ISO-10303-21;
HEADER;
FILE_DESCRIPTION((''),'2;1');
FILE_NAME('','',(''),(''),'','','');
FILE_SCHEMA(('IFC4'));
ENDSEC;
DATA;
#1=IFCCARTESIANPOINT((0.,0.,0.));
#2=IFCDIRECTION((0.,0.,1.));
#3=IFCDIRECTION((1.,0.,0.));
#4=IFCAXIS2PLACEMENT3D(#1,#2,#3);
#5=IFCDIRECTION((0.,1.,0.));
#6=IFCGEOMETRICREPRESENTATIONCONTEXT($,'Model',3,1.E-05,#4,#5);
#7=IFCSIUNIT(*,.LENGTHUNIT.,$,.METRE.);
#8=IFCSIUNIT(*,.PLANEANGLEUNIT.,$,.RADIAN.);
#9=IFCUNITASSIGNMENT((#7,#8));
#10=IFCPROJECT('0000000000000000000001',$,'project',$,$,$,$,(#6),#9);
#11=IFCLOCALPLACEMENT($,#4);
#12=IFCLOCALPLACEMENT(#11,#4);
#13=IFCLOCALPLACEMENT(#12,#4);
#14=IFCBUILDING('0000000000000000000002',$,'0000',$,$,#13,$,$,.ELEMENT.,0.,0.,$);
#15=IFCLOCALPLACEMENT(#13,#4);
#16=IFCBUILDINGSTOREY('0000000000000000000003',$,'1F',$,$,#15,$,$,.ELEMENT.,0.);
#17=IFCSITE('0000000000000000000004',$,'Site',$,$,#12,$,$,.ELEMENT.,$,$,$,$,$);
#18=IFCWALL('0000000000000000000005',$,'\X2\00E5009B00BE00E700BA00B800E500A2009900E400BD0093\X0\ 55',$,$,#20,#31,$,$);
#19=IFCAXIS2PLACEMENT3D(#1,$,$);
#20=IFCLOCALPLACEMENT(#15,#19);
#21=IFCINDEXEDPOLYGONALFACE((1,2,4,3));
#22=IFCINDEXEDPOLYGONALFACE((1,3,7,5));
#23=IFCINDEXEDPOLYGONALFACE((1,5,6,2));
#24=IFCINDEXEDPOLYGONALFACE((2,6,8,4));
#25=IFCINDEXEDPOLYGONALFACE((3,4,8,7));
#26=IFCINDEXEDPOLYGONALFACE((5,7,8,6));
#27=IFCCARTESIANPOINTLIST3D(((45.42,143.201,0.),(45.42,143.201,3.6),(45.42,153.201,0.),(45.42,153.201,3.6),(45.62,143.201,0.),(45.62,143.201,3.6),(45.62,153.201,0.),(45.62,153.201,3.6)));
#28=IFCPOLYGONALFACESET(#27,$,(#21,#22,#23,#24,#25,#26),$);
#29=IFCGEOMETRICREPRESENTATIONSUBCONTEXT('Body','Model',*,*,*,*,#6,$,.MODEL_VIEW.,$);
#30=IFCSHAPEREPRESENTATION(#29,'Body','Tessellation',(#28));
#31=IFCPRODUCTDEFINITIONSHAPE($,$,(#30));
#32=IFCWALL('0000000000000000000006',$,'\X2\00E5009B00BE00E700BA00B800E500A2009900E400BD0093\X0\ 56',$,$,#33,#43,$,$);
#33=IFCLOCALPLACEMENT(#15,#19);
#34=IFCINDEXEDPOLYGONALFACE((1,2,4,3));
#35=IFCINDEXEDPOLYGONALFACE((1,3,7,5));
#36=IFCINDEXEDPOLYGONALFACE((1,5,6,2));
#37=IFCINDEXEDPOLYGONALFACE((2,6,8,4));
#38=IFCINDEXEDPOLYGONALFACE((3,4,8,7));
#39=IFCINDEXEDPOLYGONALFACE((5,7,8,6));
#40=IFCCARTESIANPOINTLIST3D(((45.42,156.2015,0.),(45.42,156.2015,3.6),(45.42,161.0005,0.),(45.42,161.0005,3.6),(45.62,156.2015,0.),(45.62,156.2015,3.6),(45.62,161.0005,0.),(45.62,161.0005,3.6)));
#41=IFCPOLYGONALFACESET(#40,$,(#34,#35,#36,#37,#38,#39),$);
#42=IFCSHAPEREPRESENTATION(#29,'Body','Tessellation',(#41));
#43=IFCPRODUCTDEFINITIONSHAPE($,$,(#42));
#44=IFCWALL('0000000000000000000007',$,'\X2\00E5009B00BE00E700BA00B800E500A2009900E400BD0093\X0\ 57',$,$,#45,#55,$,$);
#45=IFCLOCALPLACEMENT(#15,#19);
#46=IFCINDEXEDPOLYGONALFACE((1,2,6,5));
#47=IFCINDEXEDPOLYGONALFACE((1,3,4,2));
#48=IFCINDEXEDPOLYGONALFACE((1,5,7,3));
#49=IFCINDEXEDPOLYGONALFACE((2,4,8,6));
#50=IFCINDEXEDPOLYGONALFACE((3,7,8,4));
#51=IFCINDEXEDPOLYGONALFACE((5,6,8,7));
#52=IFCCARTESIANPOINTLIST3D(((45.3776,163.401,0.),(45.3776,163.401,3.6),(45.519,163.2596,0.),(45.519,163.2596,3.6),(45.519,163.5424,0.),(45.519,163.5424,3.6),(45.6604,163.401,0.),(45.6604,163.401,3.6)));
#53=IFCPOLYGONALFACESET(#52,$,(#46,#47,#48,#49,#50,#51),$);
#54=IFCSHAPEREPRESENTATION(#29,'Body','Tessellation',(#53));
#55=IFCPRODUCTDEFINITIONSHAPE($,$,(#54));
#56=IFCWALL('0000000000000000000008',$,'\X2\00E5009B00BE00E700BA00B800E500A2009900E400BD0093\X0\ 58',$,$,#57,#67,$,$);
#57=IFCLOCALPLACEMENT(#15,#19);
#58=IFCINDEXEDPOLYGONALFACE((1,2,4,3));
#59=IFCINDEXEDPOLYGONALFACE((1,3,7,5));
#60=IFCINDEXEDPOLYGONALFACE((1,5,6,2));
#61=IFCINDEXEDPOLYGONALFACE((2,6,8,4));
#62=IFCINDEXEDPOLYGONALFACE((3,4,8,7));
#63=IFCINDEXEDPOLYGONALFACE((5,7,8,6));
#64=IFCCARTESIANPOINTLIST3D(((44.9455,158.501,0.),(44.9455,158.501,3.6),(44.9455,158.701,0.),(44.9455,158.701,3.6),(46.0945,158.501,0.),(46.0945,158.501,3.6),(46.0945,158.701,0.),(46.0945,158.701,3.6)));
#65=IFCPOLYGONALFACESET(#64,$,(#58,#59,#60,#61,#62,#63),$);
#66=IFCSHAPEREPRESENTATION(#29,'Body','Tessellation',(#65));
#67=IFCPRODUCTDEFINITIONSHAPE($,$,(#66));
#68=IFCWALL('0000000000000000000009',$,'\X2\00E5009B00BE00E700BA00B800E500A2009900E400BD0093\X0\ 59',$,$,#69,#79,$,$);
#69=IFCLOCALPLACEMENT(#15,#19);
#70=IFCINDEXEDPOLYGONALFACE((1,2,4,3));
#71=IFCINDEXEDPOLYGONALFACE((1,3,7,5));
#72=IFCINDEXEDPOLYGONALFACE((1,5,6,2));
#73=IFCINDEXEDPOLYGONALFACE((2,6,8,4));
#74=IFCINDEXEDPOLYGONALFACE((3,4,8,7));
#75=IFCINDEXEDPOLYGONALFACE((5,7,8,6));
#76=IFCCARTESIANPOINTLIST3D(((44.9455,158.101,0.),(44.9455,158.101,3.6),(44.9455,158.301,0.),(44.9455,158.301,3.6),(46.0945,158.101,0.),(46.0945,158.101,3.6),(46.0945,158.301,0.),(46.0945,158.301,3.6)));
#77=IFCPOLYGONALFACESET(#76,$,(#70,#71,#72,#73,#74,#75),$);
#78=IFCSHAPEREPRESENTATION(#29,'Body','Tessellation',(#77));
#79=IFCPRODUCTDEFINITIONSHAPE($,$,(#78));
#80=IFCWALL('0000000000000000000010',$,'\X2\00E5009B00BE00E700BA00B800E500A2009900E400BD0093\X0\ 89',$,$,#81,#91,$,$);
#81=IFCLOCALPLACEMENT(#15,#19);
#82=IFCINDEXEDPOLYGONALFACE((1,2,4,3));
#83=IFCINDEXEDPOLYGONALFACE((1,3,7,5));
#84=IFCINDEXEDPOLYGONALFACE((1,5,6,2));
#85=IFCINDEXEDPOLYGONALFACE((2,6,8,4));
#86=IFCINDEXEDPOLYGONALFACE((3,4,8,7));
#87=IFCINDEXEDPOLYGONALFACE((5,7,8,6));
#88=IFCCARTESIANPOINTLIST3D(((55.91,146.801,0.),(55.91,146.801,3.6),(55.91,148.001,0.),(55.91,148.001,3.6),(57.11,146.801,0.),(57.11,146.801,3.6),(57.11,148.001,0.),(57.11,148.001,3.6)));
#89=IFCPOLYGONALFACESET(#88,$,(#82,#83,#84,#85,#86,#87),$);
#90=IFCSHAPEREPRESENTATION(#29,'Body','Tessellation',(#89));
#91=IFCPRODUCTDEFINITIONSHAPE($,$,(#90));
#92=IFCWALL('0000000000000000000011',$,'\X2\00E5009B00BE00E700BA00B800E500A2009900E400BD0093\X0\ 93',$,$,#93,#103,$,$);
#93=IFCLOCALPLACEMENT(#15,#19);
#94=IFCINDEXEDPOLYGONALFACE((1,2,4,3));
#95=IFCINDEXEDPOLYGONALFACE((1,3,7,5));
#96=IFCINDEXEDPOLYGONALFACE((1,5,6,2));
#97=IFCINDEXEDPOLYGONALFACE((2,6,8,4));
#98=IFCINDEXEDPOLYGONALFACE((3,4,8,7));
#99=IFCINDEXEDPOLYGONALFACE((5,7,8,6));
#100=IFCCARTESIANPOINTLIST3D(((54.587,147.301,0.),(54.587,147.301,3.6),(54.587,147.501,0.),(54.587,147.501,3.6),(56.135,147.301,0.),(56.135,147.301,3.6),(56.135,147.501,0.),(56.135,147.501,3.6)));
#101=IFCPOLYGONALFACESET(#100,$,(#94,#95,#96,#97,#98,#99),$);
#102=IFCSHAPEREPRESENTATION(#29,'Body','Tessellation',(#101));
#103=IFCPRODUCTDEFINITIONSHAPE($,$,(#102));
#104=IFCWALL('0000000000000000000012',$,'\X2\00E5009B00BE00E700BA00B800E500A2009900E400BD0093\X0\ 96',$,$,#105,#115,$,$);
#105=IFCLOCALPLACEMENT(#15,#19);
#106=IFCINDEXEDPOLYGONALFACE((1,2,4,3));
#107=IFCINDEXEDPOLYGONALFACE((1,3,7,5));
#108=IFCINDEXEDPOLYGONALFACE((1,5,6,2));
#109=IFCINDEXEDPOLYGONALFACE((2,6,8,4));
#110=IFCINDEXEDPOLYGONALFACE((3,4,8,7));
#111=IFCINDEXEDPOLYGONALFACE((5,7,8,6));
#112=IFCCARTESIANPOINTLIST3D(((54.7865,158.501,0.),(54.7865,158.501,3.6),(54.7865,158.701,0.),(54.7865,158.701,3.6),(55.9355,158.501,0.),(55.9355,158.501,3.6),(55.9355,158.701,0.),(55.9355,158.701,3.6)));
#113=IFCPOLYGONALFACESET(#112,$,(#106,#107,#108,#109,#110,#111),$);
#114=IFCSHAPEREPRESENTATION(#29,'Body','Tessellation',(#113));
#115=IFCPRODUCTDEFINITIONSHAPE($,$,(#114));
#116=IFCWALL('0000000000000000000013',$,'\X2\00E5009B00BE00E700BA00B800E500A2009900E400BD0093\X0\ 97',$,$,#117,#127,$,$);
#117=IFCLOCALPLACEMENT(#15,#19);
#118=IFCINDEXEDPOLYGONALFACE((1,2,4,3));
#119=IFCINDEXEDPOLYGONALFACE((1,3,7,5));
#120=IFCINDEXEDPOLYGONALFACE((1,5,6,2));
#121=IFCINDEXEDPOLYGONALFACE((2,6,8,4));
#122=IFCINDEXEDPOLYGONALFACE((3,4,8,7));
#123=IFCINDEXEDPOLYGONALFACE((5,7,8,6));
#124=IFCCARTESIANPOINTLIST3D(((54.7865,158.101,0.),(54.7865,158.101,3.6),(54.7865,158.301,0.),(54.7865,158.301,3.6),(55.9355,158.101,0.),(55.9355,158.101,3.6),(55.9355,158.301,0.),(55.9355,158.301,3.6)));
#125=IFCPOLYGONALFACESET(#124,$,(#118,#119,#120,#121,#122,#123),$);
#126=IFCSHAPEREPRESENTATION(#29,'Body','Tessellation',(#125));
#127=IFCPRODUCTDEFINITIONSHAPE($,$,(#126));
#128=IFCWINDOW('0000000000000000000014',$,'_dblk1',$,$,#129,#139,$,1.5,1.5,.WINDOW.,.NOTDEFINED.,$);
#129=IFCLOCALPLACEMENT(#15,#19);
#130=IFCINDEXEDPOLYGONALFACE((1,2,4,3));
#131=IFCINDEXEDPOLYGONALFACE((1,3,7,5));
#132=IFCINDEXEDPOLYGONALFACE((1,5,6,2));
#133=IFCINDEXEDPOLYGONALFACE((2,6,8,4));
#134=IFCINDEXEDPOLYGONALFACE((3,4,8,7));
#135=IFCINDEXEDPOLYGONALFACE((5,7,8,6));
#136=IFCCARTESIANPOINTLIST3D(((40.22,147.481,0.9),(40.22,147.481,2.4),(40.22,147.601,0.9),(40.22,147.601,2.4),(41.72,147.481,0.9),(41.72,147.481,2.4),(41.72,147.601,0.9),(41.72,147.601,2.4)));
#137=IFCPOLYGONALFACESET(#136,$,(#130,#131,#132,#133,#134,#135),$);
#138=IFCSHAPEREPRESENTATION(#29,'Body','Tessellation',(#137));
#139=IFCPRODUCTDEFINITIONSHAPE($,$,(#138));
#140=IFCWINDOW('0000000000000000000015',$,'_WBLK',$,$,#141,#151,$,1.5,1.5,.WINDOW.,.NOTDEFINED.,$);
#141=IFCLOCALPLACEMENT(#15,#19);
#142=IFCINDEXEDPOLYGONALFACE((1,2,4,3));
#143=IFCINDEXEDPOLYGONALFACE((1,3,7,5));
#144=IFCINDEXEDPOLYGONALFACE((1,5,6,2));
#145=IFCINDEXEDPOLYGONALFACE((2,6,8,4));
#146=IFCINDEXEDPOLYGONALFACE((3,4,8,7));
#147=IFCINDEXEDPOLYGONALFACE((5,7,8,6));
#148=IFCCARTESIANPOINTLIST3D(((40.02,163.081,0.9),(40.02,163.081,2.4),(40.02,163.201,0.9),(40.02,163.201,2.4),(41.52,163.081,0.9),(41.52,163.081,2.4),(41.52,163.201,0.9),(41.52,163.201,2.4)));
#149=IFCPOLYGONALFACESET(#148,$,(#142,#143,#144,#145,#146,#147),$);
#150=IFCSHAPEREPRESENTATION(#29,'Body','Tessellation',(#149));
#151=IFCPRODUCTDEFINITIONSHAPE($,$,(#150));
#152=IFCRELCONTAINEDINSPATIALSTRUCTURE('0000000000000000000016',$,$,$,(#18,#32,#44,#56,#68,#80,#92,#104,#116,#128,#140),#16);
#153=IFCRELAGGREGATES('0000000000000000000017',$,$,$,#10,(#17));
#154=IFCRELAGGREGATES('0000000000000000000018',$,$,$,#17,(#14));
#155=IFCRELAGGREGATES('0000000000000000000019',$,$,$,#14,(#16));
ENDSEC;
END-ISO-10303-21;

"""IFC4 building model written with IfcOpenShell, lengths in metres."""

from ifc_helpers import new_model, si_unit, direction, frame, frame_2d, origin_with_axes, place, context, subcontext, project, spatial, rectangle, extrude, element, save


model = new_model("IFC4")

# Units and contexts
model_context = context("Model", 3, precision=1e-05, world=origin_with_axes(), true_north=direction((0.0, 1.0, 0.0)))
body_context = subcontext(model_context, "Body", "Model", "MODEL_VIEW")
ifc_project = project(units=[si_unit("LENGTHUNIT", "METRE"), si_unit("PLANEANGLEUNIT", "RADIAN")], contexts=[model_context])

# Site, building, storey
placement = place(None, origin_with_axes())
site_placement = place(placement, origin_with_axes())
site = spatial("IfcSite", under=ifc_project, at=site_placement, Name="Site", CompositionType="ELEMENT")
building_placement = place(site_placement, origin_with_axes())
building = spatial("IfcBuilding", under=site, at=building_placement, Name="0000", CompositionType="ELEMENT", ElevationOfRefHeight=0.0, ElevationOfTerrain=0.0)
storey_placement = place(building_placement, origin_with_axes())
storey = spatial("IfcBuildingStorey", under=building, at=storey_placement, Name="1F", CompositionType="ELEMENT", Elevation=0.0)

# Walls
wall_1_placement = place(storey_placement, frame((45.52, 148.201, 0.0), z_axis=(0.0, 0.0, 1.0), x_axis=(0.0, 1.0, 0.0)))
element("IfcWall", 1, at=wall_1_placement, inside=storey, Name="å\u009b¾çº¸å¢\u0099ä½\u0093 55", context=body_context, shape_type="SweptSolid", body=[
    extrude(rectangle(XDim=10.0, YDim=0.2, at=frame_2d((0.0, 0.0), x_axis=(1.0, 0.0, 0.0))), frame((0.0, 0.0, 0.0), z_axis=(0.0, 0.0, 1.0)), (0.0, 0.0, 1.0), 3.6),
])
wall_2_placement = place(storey_placement, frame((45.52, 158.601, 0.0), z_axis=(0.0, 0.0, 1.0), x_axis=(0.0, 1.0, 0.0)))
element("IfcWall", 2, at=wall_2_placement, inside=storey, Name="å\u009b¾çº¸å¢\u0099ä½\u0093 56", context=body_context, shape_type="SweptSolid", body=[
    extrude(rectangle(XDim=4.799, YDim=0.2, at=frame_2d((0.0, 0.0), x_axis=(1.0, 0.0, 0.0))), frame((0.0, 0.0, 0.0), z_axis=(0.0, 0.0, 1.0)), (0.0, 0.0, 1.0), 3.6),
])
wall_3_placement = place(storey_placement, frame((45.519, 163.401, 0.0), z_axis=(0.0, 0.0, 1.0), x_axis=(0.707107, -0.707107, 0.0)))
element("IfcWall", 3, at=wall_3_placement, inside=storey, Name="å\u009b¾çº¸å¢\u0099ä½\u0093 57", context=body_context, shape_type="SweptSolid", body=[
    extrude(rectangle(XDim=0.2, YDim=0.2, at=frame_2d((0.0, 0.0), x_axis=(1.0, 0.0, 0.0))), frame((0.0, 0.0, 0.0), z_axis=(0.0, 0.0, 1.0)), (0.0, 0.0, 1.0), 3.6),
])
for number, where, z_axis, x_axis, name in (
    (4, (45.52, 158.601, 0.0), (0.0, 0.0, 1.0), (1.0, 0.0, 0.0), "å\u009b¾çº¸å¢\u0099ä½\u0093 58"),
    (5, (45.52, 158.201, 0.0), (0.0, 0.0, 1.0), (1.0, 0.0, 0.0), "å\u009b¾çº¸å¢\u0099ä½\u0093 59"),
):
    element("IfcWall", number, at=place(storey_placement, frame(where, z_axis=z_axis, x_axis=x_axis)), inside=storey, Name=name, context=body_context, shape_type="SweptSolid", body=[
        extrude(rectangle(XDim=1.149, YDim=0.2, at=frame_2d((0.0, 0.0), x_axis=(1.0, 0.0, 0.0))), frame((0.0, 0.0, 0.0), z_axis=(0.0, 0.0, 1.0)), (0.0, 0.0, 1.0), 3.6),
    ])
wall_4_placement = place(storey_placement, frame((56.51, 147.401, 0.0), z_axis=(0.0, 0.0, 1.0), x_axis=(1.0, 0.0, 0.0)))
element("IfcWall", 6, at=wall_4_placement, inside=storey, Name="å\u009b¾çº¸å¢\u0099ä½\u0093 89", context=body_context, shape_type="SweptSolid", body=[
    extrude(rectangle(XDim=1.2, YDim=1.2, at=frame_2d((0.0, 0.0), x_axis=(1.0, 0.0, 0.0))), frame((0.0, 0.0, 0.0), z_axis=(0.0, 0.0, 1.0)), (0.0, 0.0, 1.0), 3.6),
])
wall_5_placement = place(storey_placement, frame((55.361, 147.401, 0.0), z_axis=(0.0, 0.0, 1.0), x_axis=(1.0, 0.0, 0.0)))
element("IfcWall", 7, at=wall_5_placement, inside=storey, Name="å\u009b¾çº¸å¢\u0099ä½\u0093 93", context=body_context, shape_type="SweptSolid", body=[
    extrude(rectangle(XDim=1.548, YDim=0.2, at=frame_2d((0.0, 0.0), x_axis=(1.0, 0.0, 0.0))), frame((0.0, 0.0, 0.0), z_axis=(0.0, 0.0, 1.0)), (0.0, 0.0, 1.0), 3.6),
])
for number, where, z_axis, x_axis, name in (
    (8, (55.361, 158.601, 0.0), (0.0, 0.0, 1.0), (1.0, 0.0, 0.0), "å\u009b¾çº¸å¢\u0099ä½\u0093 96"),
    (9, (55.361, 158.201, 0.0), (0.0, 0.0, 1.0), (1.0, 0.0, 0.0), "å\u009b¾çº¸å¢\u0099ä½\u0093 97"),
):
    element("IfcWall", number, at=place(storey_placement, frame(where, z_axis=z_axis, x_axis=x_axis)), inside=storey, Name=name, context=body_context, shape_type="SweptSolid", body=[
        extrude(rectangle(XDim=1.149, YDim=0.2, at=frame_2d((0.0, 0.0), x_axis=(1.0, 0.0, 0.0))), frame((0.0, 0.0, 0.0), z_axis=(0.0, 0.0, 1.0)), (0.0, 0.0, 1.0), 3.6),
    ])

# Windows
for number, where, z_axis, x_axis, name in (
    (10, (40.97, 147.541, 0.9), (0.0, 0.0, 1.0), (1.0, 0.0, 0.0), "_dblk1"),
    (11, (40.77, 163.141, 0.9), (0.0, 0.0, 1.0), (1.0, 0.0, 0.0), "_WBLK"),
):
    element("IfcWindow", number, at=place(storey_placement, frame(where, z_axis=z_axis, x_axis=x_axis)), inside=storey, Name=name, OverallHeight=1.5, OverallWidth=1.5, PartitioningType="NOTDEFINED", PredefinedType="WINDOW", context=body_context, shape_type="SweptSolid", body=[
        extrude(rectangle(XDim=1.5, YDim=0.12, at=frame_2d((0.0, 0.0), x_axis=(1.0, 0.0, 0.0))), frame((0.0, 0.0, 0.0), z_axis=(0.0, 0.0, 1.0)), (0.0, 0.0, 1.0), 1.5),
    ])

save(model, "model.ifc")
